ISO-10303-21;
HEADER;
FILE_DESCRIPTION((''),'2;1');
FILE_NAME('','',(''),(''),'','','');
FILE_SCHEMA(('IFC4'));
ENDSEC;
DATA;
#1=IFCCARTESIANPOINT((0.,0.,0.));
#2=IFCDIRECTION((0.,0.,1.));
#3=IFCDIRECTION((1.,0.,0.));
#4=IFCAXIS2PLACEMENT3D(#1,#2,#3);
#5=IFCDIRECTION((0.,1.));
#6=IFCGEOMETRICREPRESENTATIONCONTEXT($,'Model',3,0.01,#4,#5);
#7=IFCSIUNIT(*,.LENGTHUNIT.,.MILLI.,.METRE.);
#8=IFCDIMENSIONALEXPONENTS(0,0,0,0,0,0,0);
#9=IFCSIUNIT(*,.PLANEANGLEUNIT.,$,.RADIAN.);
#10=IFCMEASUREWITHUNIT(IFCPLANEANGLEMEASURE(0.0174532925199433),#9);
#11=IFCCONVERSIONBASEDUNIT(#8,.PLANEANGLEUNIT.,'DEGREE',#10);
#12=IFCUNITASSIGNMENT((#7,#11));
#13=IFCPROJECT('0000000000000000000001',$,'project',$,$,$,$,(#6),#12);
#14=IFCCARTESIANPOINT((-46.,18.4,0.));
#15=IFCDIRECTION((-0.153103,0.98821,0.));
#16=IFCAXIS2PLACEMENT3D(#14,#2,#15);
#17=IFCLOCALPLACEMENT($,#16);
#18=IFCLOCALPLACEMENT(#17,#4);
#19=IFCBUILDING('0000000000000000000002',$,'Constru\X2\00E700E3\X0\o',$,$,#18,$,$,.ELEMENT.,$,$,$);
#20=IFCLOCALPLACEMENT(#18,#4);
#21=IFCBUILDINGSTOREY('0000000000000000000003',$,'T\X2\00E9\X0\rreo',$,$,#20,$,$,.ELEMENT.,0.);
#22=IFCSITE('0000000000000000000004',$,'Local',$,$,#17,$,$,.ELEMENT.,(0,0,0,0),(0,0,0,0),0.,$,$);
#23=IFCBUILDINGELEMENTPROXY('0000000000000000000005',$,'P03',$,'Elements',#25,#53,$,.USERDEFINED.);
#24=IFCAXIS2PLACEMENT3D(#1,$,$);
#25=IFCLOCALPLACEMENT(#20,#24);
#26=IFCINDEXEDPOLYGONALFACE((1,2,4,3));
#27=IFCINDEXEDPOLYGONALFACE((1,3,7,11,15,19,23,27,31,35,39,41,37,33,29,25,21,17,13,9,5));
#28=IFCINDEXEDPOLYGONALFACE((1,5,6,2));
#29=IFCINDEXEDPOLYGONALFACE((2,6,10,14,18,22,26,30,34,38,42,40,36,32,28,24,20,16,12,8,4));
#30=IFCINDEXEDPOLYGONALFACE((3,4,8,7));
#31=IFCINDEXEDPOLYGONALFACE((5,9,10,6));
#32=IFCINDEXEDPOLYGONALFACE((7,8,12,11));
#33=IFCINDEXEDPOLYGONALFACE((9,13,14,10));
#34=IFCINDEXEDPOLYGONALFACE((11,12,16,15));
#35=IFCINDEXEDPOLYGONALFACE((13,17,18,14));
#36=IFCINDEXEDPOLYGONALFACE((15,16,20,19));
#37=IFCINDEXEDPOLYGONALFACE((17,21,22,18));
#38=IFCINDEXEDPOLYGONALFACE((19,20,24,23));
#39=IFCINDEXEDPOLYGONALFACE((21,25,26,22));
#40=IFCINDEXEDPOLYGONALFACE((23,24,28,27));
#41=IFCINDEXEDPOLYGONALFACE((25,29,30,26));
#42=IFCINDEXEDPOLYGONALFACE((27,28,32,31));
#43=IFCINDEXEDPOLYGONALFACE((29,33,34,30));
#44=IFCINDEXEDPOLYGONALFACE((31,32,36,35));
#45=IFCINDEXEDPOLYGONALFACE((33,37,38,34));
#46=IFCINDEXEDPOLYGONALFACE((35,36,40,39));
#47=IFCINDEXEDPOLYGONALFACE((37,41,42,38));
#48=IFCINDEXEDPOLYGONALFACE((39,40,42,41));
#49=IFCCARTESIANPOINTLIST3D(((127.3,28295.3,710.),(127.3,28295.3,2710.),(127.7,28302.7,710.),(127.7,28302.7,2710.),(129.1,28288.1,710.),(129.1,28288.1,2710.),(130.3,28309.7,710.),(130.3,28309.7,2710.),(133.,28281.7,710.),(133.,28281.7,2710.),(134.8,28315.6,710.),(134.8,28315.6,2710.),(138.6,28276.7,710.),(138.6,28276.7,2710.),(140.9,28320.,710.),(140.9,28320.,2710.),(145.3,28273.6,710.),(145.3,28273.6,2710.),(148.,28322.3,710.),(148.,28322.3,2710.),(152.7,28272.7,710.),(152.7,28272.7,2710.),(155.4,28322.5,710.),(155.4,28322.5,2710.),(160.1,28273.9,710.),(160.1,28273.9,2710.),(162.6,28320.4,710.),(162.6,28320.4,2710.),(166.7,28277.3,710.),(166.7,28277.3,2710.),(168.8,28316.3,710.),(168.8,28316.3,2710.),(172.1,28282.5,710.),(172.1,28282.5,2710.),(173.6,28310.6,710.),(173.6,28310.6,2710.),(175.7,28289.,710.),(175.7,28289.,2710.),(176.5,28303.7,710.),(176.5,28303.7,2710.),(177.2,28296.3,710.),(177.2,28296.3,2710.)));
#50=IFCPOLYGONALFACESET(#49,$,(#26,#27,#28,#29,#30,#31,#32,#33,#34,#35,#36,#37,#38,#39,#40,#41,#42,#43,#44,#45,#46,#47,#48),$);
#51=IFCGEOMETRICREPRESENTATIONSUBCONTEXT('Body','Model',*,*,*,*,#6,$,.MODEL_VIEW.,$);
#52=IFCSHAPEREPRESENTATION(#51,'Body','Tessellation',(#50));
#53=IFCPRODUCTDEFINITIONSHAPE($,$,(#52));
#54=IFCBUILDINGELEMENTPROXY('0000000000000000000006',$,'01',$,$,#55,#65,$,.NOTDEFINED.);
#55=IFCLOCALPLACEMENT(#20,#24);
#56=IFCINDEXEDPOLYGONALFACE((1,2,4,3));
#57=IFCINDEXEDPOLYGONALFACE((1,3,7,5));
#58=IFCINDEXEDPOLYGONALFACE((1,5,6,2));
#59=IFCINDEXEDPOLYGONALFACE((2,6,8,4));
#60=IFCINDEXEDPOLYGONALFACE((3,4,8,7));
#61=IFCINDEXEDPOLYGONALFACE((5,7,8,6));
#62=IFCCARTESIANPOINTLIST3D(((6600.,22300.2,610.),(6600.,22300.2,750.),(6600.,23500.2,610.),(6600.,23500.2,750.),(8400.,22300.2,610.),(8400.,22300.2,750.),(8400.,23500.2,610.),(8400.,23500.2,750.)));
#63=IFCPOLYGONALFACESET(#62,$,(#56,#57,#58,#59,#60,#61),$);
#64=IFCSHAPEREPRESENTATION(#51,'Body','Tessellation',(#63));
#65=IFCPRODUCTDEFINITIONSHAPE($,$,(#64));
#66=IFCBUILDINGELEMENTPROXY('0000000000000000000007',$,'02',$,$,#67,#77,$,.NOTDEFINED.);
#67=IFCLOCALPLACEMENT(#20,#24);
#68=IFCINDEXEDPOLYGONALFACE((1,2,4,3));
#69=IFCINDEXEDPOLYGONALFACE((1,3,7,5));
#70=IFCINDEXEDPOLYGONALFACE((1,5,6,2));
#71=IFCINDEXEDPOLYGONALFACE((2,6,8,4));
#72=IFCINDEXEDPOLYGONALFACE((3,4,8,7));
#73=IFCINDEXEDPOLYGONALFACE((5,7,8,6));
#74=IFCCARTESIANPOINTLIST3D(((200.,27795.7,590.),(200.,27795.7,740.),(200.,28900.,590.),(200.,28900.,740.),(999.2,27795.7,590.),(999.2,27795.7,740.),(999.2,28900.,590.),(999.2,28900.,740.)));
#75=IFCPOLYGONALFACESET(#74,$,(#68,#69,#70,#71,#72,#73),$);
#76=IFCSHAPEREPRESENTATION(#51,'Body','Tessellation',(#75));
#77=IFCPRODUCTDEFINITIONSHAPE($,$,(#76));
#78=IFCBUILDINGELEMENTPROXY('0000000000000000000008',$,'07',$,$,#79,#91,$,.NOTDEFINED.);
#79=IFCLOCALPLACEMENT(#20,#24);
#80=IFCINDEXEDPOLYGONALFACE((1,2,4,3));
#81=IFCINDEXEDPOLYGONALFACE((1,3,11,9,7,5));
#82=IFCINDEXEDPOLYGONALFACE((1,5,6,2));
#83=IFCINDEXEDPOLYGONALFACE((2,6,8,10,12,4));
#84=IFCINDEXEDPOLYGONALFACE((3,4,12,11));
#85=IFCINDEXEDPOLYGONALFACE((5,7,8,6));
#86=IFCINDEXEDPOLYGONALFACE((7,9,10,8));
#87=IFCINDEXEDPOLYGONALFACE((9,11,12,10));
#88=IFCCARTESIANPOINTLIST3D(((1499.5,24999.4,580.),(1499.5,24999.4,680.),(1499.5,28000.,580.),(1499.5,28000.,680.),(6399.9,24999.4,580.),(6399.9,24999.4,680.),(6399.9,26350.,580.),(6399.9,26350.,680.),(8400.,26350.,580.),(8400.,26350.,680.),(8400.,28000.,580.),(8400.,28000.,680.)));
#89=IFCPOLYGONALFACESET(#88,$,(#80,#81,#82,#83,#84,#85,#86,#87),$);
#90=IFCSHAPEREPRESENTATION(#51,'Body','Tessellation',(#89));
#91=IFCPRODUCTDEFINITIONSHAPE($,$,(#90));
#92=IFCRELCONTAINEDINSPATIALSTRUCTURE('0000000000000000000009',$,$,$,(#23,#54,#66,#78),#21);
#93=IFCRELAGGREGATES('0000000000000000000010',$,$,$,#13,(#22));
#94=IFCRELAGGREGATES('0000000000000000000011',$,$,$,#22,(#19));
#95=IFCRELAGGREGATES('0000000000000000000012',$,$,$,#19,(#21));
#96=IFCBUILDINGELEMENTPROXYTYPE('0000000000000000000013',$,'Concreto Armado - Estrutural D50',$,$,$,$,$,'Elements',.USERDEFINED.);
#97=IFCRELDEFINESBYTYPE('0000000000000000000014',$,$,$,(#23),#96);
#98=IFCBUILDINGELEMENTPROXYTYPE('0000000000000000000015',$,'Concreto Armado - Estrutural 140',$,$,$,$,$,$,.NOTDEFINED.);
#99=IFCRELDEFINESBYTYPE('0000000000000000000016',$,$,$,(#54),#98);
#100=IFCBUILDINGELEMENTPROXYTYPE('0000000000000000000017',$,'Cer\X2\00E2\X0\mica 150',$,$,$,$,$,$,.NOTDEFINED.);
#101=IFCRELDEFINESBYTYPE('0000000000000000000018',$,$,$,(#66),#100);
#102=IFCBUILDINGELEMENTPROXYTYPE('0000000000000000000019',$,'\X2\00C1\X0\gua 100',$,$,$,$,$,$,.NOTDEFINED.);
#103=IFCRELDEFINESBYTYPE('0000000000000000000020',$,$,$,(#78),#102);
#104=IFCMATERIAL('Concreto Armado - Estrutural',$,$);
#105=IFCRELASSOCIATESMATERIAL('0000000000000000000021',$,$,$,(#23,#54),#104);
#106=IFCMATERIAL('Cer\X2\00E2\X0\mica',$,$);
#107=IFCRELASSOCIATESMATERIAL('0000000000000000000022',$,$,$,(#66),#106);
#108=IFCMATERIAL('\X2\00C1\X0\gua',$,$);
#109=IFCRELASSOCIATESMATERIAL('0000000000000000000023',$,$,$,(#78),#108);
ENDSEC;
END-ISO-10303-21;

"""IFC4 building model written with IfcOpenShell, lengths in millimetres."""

from ifc_helpers import new_model, entity, si_unit, converted_unit, direction, frame, origin_with_axes, origin_2d_with_axis, place, context, subcontext, project, spatial, line, indexed_curve, circle, outline, extrude, material, type_object, element, save


model = new_model("IFC4")

# Units and contexts
model_context = context("Model", 3, precision=0.01, world=origin_with_axes(), true_north=direction((0.0, 1.0)))
body_context = subcontext(model_context, "Body", "Model", "MODEL_VIEW")
ifc_project = project(units=[si_unit("LENGTHUNIT", "METRE", prefix="MILLI"), converted_unit("PLANEANGLEUNIT", "DEGREE", entity("IfcPlaneAngleMeasure", 0.0174532925199433), si_unit("PLANEANGLEUNIT", "RADIAN"), dimensions=[0, 0, 0, 0, 0, 0, 0])], contexts=[model_context])

# Site, building, storey
site_placement = place(None, frame((-46.0, 18.4, 0.0), z_axis=(0.0, 0.0, 1.0), x_axis=(-0.153103, 0.98821, 0.0)))
site = spatial("IfcSite", under=ifc_project, at=site_placement, Name="Local", CompositionType="ELEMENT", RefLatitude=(0, 0, 0, 0), RefLongitude=(0, 0, 0, 0), RefElevation=0.0)
building_placement = place(site_placement, origin_with_axes())
building = spatial("IfcBuilding", under=site, at=building_placement, Name="Construção", CompositionType="ELEMENT")
storey_placement = place(building_placement, origin_with_axes())
storey = spatial("IfcBuildingStorey", under=building, at=storey_placement, Name="Térreo", CompositionType="ELEMENT", Elevation=0.0)

# Building element proxies
ifc_material_1 = material(Name="Cerâmica")
ifc_material_2 = material(Name="Concreto Armado - Estrutural")
building_element_proxy_type_1 = type_object("IfcBuildingElementProxyType", Name="Concreto Armado - Estrutural D50", ElementType="Elements", PredefinedType="USERDEFINED")
proxy_1_placement = place(storey_placement, frame((152.2, 28297.7, 710.0), z_axis=(0.0, 0.0, 1.0), x_axis=(0.665014, 0.746831, 0.0)))
element("IfcBuildingElementProxy", 1, at=proxy_1_placement, inside=storey, type_object=building_element_proxy_type_1, material=ifc_material_2, Name="P03", ObjectType="Elements", PredefinedType="USERDEFINED", context=body_context, shape_type="SweptSolid", body=[
    extrude(circle(Radius=25.0, at=origin_2d_with_axis()), origin_with_axes(), (0.0, 0.0, 1.0), 2000.0),
])
building_element_proxy_type_2 = type_object("IfcBuildingElementProxyType", Name="Concreto Armado - Estrutural 140", PredefinedType="NOTDEFINED")
proxy_2_placement = place(storey_placement, frame((6600.0, 23500.2, 750.0), z_axis=(0.0, 0.0, 1.0), x_axis=(1.0, 0.0, 0.0)))
element("IfcBuildingElementProxy", 2, at=proxy_2_placement, inside=storey, type_object=building_element_proxy_type_2, material=ifc_material_2, Name="01", PredefinedType="NOTDEFINED", context=body_context, shape_type="SweptSolid", body=[
    extrude(outline(indexed_curve([(0.0, 0.0), (0.0, -1200.0), (1800.0, -1200.0), (1800.0, 0.0)], segments=[line(1, 2, 3, 4, 1)])), frame((0.0, 0.0, -140.0), z_axis=(0.0, 0.0, 1.0), x_axis=(1.0, 0.0, 0.0)), (0.0, 0.0, 1.0), 140.0),
])
building_element_proxy_type_3 = type_object("IfcBuildingElementProxyType", Name="Cerâmica 150", PredefinedType="NOTDEFINED")
proxy_3_placement = place(storey_placement, frame((200.0, 27795.7, 740.0), z_axis=(0.0, 0.0, 1.0), x_axis=(1.0, 0.0, 0.0)))
element("IfcBuildingElementProxy", 3, at=proxy_3_placement, inside=storey, type_object=building_element_proxy_type_3, material=ifc_material_1, Name="02", PredefinedType="NOTDEFINED", context=body_context, shape_type="SweptSolid", body=[
    extrude(outline(indexed_curve([(0.0, 0.0), (799.2, 0.0), (799.2, 1104.4), (0.0, 1104.4)], segments=[line(1, 2, 3, 4, 1)])), frame((0.0, 0.0, -150.0), z_axis=(0.0, 0.0, 1.0), x_axis=(1.0, 0.0, 0.0)), (0.0, 0.0, 1.0), 150.0),
])
ifc_material_3 = material(Name="Água")
building_element_proxy_type_4 = type_object("IfcBuildingElementProxyType", Name="Água 100", PredefinedType="NOTDEFINED")
proxy_4_placement = place(storey_placement, frame((1499.5, 28000.0, 680.0), z_axis=(0.0, 0.0, 1.0), x_axis=(1.0, 0.0, 0.0)))
element("IfcBuildingElementProxy", 4, at=proxy_4_placement, inside=storey, type_object=building_element_proxy_type_4, material=ifc_material_3, Name="07", PredefinedType="NOTDEFINED", context=body_context, shape_type="SweptSolid", body=[
    extrude(outline(indexed_curve([(0.0, 0.0), (0.0, -3000.6), (4900.5, -3000.6), (4900.5, -1650.0), (6900.5, -1650.0), (6900.5, 0.0)], segments=[line(1, 2, 3, 4, 5, 6, 1)])), frame((0.0, 0.0, -100.0), z_axis=(0.0, 0.0, 1.0), x_axis=(1.0, 0.0, 0.0)), (0.0, 0.0, 1.0), 100.0),
])

save(model, "model.ifc")
